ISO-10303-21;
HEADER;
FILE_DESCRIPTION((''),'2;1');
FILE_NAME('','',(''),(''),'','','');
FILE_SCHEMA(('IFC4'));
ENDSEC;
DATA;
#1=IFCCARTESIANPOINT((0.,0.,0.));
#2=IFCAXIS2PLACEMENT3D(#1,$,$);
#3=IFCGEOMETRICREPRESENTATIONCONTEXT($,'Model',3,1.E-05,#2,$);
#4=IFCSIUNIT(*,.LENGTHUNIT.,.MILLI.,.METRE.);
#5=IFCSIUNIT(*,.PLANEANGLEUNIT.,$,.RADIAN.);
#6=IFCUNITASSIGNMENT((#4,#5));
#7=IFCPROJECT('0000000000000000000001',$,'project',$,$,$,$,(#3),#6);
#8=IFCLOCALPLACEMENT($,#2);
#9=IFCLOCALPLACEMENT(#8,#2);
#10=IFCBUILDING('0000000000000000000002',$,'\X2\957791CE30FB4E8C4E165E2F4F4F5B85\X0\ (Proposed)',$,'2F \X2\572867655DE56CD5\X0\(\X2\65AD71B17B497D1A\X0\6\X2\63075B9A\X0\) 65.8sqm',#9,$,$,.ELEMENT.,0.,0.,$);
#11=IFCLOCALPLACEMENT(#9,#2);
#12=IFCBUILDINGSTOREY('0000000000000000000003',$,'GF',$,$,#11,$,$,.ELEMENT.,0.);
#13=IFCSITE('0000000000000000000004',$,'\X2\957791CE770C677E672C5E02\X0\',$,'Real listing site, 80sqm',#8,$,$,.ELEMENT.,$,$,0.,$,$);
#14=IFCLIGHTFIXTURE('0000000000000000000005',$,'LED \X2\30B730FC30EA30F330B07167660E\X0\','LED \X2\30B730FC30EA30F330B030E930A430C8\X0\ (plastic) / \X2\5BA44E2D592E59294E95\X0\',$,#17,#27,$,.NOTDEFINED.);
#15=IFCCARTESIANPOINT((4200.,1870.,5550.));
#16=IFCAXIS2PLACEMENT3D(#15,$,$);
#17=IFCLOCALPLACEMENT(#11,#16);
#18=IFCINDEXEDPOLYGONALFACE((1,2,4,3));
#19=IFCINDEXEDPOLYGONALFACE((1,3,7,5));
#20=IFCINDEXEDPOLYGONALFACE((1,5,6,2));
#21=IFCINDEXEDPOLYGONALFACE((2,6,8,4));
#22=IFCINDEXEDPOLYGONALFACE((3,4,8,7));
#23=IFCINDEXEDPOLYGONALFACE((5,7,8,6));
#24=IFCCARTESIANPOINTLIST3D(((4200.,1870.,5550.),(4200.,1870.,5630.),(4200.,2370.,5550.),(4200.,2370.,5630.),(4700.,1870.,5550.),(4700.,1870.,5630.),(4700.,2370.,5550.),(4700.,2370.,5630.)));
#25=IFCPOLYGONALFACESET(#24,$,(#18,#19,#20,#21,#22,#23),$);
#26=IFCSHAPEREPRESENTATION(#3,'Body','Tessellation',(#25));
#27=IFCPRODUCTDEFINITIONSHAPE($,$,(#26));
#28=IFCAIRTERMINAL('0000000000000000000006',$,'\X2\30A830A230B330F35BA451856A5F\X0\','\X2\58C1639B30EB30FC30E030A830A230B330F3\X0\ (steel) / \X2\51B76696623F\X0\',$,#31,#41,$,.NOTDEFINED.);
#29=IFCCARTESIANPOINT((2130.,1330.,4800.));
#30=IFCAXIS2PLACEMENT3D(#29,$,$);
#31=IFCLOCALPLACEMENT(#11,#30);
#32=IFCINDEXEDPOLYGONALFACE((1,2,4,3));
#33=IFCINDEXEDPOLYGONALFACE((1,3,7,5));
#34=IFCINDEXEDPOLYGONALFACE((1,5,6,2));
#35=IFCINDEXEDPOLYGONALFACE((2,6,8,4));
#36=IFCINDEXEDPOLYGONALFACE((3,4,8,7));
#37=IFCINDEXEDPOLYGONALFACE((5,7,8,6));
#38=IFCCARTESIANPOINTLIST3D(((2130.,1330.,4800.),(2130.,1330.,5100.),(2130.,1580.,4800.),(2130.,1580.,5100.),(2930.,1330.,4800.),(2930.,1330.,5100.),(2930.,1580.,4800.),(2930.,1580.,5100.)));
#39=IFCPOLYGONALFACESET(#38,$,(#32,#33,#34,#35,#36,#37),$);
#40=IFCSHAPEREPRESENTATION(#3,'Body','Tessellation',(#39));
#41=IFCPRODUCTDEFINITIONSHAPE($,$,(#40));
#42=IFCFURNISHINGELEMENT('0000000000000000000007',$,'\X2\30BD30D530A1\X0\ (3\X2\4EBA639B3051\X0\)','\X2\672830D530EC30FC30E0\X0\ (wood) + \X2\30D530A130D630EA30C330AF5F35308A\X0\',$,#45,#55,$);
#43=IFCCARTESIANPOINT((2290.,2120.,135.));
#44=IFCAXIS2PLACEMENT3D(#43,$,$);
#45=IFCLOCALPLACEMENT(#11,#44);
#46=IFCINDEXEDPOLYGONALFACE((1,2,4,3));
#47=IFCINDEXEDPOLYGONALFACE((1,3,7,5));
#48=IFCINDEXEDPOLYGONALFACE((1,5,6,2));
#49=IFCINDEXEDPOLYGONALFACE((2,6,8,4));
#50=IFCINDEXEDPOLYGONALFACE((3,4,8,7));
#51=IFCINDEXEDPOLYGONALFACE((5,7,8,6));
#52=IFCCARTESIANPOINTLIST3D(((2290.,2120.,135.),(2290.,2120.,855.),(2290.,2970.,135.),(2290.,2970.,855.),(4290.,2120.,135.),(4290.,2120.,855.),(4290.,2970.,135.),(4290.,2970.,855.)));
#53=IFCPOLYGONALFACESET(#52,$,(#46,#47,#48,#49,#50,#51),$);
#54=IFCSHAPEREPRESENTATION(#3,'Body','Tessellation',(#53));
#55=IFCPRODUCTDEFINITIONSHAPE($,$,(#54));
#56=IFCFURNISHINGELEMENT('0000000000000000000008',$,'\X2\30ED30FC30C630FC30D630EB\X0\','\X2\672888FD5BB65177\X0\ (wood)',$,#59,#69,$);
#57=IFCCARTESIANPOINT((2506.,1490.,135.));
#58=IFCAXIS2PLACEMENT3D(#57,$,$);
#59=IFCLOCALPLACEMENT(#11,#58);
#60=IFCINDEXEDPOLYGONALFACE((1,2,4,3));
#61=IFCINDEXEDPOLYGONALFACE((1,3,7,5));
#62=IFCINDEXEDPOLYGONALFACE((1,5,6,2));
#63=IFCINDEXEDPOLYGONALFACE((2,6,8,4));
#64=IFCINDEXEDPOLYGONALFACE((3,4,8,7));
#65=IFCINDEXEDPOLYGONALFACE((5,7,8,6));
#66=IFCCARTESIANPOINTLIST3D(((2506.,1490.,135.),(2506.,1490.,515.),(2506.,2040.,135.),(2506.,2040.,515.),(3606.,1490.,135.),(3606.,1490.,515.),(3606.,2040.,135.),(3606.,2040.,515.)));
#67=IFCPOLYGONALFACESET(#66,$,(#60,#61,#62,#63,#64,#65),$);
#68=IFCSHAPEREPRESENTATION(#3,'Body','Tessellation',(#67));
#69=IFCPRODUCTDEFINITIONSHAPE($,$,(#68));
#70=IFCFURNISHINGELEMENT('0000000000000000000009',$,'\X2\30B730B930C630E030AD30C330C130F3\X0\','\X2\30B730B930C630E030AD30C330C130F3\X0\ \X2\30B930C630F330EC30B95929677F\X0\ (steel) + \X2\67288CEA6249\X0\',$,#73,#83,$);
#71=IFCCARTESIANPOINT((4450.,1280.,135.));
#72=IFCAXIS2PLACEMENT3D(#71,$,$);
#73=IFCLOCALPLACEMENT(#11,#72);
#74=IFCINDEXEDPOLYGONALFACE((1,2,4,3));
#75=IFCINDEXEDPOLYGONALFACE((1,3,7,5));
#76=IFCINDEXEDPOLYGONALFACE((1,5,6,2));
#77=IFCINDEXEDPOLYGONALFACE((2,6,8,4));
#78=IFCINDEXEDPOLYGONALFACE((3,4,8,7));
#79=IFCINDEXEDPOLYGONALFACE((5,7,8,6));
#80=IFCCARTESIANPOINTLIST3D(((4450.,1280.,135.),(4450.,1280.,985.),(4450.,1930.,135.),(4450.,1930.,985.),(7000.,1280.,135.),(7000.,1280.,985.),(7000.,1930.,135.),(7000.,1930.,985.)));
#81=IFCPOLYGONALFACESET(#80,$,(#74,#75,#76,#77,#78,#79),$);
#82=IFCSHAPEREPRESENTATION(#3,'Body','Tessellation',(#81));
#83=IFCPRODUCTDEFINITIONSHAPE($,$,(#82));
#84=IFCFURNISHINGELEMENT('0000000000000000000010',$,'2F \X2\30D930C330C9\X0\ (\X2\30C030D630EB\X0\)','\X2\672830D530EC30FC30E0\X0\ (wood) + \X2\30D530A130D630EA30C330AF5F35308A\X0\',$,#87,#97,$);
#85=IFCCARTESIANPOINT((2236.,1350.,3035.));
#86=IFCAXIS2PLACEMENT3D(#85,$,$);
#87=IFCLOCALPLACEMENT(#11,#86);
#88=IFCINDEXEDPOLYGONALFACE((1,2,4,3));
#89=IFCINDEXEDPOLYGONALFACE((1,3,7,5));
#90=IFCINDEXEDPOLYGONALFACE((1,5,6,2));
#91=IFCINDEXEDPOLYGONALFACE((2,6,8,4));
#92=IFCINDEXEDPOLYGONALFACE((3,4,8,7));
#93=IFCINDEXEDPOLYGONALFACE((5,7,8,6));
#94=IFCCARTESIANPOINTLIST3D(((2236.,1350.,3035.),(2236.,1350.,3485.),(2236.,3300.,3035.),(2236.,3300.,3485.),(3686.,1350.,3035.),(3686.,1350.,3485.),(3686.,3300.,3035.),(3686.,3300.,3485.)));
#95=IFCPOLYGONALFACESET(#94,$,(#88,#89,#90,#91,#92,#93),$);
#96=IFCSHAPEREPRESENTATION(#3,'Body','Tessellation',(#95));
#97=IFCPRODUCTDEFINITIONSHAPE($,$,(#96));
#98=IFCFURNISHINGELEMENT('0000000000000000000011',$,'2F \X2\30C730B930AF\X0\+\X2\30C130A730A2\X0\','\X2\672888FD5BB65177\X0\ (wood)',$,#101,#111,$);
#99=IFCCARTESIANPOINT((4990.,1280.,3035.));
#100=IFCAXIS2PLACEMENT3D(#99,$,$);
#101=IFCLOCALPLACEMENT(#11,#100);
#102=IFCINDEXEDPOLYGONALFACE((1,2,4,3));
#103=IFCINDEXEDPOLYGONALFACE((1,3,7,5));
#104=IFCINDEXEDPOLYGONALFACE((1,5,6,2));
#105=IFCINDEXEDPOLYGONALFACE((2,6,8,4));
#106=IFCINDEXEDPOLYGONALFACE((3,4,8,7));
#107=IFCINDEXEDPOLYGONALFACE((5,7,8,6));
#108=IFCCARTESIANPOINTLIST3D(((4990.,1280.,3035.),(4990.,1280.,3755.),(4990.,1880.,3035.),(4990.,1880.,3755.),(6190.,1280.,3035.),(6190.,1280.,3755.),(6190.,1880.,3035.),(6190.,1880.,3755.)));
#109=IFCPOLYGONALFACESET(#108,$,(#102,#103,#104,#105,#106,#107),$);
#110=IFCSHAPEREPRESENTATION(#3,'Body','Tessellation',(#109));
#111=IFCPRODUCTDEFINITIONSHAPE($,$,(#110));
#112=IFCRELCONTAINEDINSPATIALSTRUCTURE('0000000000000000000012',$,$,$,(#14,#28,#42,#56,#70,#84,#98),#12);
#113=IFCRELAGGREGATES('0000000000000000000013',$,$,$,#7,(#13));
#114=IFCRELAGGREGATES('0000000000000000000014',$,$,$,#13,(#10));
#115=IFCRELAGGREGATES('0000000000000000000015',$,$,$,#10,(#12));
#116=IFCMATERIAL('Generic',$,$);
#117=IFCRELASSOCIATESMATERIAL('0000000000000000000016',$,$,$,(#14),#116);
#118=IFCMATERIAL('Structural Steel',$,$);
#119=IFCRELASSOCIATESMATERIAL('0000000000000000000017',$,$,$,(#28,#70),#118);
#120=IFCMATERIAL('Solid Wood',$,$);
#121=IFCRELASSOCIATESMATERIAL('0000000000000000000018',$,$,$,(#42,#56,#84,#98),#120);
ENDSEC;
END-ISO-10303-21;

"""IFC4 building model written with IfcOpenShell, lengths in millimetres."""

from ifc_helpers import new_model, si_unit, frame, frame_2d, origin, place, context, project, spatial, rectangle, extrude, material, element, save


model = new_model("IFC4")

# Units and contexts
model_context = context("Model", 3, precision=1e-05, world=origin())
ifc_project = project(units=[si_unit("LENGTHUNIT", "METRE", prefix="MILLI"), si_unit("PLANEANGLEUNIT", "RADIAN")], contexts=[model_context])

# Site, building, storey
site_placement = place(None, origin())
site = spatial("IfcSite", under=ifc_project, at=site_placement, Name="長野県松本市", ObjectType="Real listing site, 80sqm", CompositionType="ELEMENT", RefElevation=0.0)
building_placement = place(site_placement, origin())
building = spatial("IfcBuilding", under=site, at=building_placement, Name="長野・二世帯住宅 (Proposed)", ObjectType="2F 在来工法(断熱等級6指定) 65.8sqm", CompositionType="ELEMENT", ElevationOfRefHeight=0.0, ElevationOfTerrain=0.0)
storey_placement = place(building_placement, origin())
storey = spatial("IfcBuildingStorey", under=building, at=storey_placement, Name="GF", CompositionType="ELEMENT", Elevation=0.0)

# Shared definitions
ifc_material_1 = material(Name="Solid Wood")

# Shared definitions
ifc_material_2 = material(Name="Generic")

# Shared definitions
ifc_material_3 = material(Name="Structural Steel")

# Light fixture
light_fixture_1_placement = place(storey_placement, frame((4200.0, 1870.0, 5550.0)))
element("IfcLightFixture", 1, at=light_fixture_1_placement, inside=storey, material=ifc_material_2, Name="LED シーリング照明", Description="LED シーリングライト (plastic) / 室中央天井", PredefinedType="NOTDEFINED", context=model_context, shape_type="SweptSolid", body=[
    extrude(rectangle(XDim=500.0, YDim=500.0, at=frame_2d((250.0, 250.0))), frame((4200.0, 1870.0, 5550.0)), (0.0, 0.0, 1.0), 80.0),
])

# Air terminal
air_terminal_placement = place(storey_placement, frame((2130.0, 1330.0, 4800.0)))
element("IfcAirTerminal", 2, at=air_terminal_placement, inside=storey, material=ifc_material_3, Name="エアコン室内機", Description="壁掛ルームエアコン (steel) / 冷暖房", PredefinedType="NOTDEFINED", context=model_context, shape_type="SweptSolid", body=[
    extrude(rectangle(XDim=800.0, YDim=250.0, at=frame_2d((400.0, 125.0))), frame((2130.0, 1330.0, 4800.0)), (0.0, 0.0, 1.0), 300.0),
])

# Furnishing elements
furnishing_1_placement = place(storey_placement, frame((2290.0, 2120.0, 135.0)))
element("IfcFurnishingElement", 3, at=furnishing_1_placement, inside=storey, material=ifc_material_1, Name="ソファ (3人掛け)", Description="木フレーム (wood) + ファブリック張り", context=model_context, shape_type="SweptSolid", body=[
    extrude(rectangle(XDim=2000.0, YDim=850.0, at=frame_2d((1000.0, 425.0))), frame((2290.0, 2120.0, 135.0)), (0.0, 0.0, 1.0), 720.0),
])
furnishing_2_placement = place(storey_placement, frame((2506.0, 1490.0, 135.0)))
element("IfcFurnishingElement", 4, at=furnishing_2_placement, inside=storey, material=ifc_material_1, Name="ローテーブル", Description="木製家具 (wood)", context=model_context, shape_type="SweptSolid", body=[
    extrude(rectangle(XDim=1100.0, YDim=550.0, at=frame_2d((550.0, 275.0))), frame((2506.0, 1490.0, 135.0)), (0.0, 0.0, 1.0), 380.0),
])
furnishing_3_placement = place(storey_placement, frame((4450.0, 1280.0, 135.0)))
element("IfcFurnishingElement", 5, at=furnishing_3_placement, inside=storey, material=ifc_material_3, Name="システムキッチン", Description="システムキッチン ステンレス天板 (steel) + 木質扉", context=model_context, shape_type="SweptSolid", body=[
    extrude(rectangle(XDim=2550.0, YDim=650.0, at=frame_2d((1275.0, 325.0))), frame((4450.0, 1280.0, 135.0)), (0.0, 0.0, 1.0), 850.0),
])
furnishing_4_placement = place(storey_placement, frame((2236.0, 1350.0, 3035.0)))
element("IfcFurnishingElement", 6, at=furnishing_4_placement, inside=storey, material=ifc_material_1, Name="2F ベッド (ダブル)", Description="木フレーム (wood) + ファブリック張り", context=model_context, shape_type="SweptSolid", body=[
    extrude(rectangle(XDim=1450.0, YDim=1950.0, at=frame_2d((725.0, 975.0))), frame((2236.0, 1350.0, 3035.0)), (0.0, 0.0, 1.0), 450.0),
])
furnishing_5_placement = place(storey_placement, frame((4990.0, 1280.0, 3035.0)))
element("IfcFurnishingElement", 7, at=furnishing_5_placement, inside=storey, material=ifc_material_1, Name="2F デスク+チェア", Description="木製家具 (wood)", context=model_context, shape_type="SweptSolid", body=[
    extrude(rectangle(XDim=1200.0, YDim=600.0, at=frame_2d((600.0, 300.0))), frame((4990.0, 1280.0, 3035.0)), (0.0, 0.0, 1.0), 720.0),
])

save(model, "model.ifc")
